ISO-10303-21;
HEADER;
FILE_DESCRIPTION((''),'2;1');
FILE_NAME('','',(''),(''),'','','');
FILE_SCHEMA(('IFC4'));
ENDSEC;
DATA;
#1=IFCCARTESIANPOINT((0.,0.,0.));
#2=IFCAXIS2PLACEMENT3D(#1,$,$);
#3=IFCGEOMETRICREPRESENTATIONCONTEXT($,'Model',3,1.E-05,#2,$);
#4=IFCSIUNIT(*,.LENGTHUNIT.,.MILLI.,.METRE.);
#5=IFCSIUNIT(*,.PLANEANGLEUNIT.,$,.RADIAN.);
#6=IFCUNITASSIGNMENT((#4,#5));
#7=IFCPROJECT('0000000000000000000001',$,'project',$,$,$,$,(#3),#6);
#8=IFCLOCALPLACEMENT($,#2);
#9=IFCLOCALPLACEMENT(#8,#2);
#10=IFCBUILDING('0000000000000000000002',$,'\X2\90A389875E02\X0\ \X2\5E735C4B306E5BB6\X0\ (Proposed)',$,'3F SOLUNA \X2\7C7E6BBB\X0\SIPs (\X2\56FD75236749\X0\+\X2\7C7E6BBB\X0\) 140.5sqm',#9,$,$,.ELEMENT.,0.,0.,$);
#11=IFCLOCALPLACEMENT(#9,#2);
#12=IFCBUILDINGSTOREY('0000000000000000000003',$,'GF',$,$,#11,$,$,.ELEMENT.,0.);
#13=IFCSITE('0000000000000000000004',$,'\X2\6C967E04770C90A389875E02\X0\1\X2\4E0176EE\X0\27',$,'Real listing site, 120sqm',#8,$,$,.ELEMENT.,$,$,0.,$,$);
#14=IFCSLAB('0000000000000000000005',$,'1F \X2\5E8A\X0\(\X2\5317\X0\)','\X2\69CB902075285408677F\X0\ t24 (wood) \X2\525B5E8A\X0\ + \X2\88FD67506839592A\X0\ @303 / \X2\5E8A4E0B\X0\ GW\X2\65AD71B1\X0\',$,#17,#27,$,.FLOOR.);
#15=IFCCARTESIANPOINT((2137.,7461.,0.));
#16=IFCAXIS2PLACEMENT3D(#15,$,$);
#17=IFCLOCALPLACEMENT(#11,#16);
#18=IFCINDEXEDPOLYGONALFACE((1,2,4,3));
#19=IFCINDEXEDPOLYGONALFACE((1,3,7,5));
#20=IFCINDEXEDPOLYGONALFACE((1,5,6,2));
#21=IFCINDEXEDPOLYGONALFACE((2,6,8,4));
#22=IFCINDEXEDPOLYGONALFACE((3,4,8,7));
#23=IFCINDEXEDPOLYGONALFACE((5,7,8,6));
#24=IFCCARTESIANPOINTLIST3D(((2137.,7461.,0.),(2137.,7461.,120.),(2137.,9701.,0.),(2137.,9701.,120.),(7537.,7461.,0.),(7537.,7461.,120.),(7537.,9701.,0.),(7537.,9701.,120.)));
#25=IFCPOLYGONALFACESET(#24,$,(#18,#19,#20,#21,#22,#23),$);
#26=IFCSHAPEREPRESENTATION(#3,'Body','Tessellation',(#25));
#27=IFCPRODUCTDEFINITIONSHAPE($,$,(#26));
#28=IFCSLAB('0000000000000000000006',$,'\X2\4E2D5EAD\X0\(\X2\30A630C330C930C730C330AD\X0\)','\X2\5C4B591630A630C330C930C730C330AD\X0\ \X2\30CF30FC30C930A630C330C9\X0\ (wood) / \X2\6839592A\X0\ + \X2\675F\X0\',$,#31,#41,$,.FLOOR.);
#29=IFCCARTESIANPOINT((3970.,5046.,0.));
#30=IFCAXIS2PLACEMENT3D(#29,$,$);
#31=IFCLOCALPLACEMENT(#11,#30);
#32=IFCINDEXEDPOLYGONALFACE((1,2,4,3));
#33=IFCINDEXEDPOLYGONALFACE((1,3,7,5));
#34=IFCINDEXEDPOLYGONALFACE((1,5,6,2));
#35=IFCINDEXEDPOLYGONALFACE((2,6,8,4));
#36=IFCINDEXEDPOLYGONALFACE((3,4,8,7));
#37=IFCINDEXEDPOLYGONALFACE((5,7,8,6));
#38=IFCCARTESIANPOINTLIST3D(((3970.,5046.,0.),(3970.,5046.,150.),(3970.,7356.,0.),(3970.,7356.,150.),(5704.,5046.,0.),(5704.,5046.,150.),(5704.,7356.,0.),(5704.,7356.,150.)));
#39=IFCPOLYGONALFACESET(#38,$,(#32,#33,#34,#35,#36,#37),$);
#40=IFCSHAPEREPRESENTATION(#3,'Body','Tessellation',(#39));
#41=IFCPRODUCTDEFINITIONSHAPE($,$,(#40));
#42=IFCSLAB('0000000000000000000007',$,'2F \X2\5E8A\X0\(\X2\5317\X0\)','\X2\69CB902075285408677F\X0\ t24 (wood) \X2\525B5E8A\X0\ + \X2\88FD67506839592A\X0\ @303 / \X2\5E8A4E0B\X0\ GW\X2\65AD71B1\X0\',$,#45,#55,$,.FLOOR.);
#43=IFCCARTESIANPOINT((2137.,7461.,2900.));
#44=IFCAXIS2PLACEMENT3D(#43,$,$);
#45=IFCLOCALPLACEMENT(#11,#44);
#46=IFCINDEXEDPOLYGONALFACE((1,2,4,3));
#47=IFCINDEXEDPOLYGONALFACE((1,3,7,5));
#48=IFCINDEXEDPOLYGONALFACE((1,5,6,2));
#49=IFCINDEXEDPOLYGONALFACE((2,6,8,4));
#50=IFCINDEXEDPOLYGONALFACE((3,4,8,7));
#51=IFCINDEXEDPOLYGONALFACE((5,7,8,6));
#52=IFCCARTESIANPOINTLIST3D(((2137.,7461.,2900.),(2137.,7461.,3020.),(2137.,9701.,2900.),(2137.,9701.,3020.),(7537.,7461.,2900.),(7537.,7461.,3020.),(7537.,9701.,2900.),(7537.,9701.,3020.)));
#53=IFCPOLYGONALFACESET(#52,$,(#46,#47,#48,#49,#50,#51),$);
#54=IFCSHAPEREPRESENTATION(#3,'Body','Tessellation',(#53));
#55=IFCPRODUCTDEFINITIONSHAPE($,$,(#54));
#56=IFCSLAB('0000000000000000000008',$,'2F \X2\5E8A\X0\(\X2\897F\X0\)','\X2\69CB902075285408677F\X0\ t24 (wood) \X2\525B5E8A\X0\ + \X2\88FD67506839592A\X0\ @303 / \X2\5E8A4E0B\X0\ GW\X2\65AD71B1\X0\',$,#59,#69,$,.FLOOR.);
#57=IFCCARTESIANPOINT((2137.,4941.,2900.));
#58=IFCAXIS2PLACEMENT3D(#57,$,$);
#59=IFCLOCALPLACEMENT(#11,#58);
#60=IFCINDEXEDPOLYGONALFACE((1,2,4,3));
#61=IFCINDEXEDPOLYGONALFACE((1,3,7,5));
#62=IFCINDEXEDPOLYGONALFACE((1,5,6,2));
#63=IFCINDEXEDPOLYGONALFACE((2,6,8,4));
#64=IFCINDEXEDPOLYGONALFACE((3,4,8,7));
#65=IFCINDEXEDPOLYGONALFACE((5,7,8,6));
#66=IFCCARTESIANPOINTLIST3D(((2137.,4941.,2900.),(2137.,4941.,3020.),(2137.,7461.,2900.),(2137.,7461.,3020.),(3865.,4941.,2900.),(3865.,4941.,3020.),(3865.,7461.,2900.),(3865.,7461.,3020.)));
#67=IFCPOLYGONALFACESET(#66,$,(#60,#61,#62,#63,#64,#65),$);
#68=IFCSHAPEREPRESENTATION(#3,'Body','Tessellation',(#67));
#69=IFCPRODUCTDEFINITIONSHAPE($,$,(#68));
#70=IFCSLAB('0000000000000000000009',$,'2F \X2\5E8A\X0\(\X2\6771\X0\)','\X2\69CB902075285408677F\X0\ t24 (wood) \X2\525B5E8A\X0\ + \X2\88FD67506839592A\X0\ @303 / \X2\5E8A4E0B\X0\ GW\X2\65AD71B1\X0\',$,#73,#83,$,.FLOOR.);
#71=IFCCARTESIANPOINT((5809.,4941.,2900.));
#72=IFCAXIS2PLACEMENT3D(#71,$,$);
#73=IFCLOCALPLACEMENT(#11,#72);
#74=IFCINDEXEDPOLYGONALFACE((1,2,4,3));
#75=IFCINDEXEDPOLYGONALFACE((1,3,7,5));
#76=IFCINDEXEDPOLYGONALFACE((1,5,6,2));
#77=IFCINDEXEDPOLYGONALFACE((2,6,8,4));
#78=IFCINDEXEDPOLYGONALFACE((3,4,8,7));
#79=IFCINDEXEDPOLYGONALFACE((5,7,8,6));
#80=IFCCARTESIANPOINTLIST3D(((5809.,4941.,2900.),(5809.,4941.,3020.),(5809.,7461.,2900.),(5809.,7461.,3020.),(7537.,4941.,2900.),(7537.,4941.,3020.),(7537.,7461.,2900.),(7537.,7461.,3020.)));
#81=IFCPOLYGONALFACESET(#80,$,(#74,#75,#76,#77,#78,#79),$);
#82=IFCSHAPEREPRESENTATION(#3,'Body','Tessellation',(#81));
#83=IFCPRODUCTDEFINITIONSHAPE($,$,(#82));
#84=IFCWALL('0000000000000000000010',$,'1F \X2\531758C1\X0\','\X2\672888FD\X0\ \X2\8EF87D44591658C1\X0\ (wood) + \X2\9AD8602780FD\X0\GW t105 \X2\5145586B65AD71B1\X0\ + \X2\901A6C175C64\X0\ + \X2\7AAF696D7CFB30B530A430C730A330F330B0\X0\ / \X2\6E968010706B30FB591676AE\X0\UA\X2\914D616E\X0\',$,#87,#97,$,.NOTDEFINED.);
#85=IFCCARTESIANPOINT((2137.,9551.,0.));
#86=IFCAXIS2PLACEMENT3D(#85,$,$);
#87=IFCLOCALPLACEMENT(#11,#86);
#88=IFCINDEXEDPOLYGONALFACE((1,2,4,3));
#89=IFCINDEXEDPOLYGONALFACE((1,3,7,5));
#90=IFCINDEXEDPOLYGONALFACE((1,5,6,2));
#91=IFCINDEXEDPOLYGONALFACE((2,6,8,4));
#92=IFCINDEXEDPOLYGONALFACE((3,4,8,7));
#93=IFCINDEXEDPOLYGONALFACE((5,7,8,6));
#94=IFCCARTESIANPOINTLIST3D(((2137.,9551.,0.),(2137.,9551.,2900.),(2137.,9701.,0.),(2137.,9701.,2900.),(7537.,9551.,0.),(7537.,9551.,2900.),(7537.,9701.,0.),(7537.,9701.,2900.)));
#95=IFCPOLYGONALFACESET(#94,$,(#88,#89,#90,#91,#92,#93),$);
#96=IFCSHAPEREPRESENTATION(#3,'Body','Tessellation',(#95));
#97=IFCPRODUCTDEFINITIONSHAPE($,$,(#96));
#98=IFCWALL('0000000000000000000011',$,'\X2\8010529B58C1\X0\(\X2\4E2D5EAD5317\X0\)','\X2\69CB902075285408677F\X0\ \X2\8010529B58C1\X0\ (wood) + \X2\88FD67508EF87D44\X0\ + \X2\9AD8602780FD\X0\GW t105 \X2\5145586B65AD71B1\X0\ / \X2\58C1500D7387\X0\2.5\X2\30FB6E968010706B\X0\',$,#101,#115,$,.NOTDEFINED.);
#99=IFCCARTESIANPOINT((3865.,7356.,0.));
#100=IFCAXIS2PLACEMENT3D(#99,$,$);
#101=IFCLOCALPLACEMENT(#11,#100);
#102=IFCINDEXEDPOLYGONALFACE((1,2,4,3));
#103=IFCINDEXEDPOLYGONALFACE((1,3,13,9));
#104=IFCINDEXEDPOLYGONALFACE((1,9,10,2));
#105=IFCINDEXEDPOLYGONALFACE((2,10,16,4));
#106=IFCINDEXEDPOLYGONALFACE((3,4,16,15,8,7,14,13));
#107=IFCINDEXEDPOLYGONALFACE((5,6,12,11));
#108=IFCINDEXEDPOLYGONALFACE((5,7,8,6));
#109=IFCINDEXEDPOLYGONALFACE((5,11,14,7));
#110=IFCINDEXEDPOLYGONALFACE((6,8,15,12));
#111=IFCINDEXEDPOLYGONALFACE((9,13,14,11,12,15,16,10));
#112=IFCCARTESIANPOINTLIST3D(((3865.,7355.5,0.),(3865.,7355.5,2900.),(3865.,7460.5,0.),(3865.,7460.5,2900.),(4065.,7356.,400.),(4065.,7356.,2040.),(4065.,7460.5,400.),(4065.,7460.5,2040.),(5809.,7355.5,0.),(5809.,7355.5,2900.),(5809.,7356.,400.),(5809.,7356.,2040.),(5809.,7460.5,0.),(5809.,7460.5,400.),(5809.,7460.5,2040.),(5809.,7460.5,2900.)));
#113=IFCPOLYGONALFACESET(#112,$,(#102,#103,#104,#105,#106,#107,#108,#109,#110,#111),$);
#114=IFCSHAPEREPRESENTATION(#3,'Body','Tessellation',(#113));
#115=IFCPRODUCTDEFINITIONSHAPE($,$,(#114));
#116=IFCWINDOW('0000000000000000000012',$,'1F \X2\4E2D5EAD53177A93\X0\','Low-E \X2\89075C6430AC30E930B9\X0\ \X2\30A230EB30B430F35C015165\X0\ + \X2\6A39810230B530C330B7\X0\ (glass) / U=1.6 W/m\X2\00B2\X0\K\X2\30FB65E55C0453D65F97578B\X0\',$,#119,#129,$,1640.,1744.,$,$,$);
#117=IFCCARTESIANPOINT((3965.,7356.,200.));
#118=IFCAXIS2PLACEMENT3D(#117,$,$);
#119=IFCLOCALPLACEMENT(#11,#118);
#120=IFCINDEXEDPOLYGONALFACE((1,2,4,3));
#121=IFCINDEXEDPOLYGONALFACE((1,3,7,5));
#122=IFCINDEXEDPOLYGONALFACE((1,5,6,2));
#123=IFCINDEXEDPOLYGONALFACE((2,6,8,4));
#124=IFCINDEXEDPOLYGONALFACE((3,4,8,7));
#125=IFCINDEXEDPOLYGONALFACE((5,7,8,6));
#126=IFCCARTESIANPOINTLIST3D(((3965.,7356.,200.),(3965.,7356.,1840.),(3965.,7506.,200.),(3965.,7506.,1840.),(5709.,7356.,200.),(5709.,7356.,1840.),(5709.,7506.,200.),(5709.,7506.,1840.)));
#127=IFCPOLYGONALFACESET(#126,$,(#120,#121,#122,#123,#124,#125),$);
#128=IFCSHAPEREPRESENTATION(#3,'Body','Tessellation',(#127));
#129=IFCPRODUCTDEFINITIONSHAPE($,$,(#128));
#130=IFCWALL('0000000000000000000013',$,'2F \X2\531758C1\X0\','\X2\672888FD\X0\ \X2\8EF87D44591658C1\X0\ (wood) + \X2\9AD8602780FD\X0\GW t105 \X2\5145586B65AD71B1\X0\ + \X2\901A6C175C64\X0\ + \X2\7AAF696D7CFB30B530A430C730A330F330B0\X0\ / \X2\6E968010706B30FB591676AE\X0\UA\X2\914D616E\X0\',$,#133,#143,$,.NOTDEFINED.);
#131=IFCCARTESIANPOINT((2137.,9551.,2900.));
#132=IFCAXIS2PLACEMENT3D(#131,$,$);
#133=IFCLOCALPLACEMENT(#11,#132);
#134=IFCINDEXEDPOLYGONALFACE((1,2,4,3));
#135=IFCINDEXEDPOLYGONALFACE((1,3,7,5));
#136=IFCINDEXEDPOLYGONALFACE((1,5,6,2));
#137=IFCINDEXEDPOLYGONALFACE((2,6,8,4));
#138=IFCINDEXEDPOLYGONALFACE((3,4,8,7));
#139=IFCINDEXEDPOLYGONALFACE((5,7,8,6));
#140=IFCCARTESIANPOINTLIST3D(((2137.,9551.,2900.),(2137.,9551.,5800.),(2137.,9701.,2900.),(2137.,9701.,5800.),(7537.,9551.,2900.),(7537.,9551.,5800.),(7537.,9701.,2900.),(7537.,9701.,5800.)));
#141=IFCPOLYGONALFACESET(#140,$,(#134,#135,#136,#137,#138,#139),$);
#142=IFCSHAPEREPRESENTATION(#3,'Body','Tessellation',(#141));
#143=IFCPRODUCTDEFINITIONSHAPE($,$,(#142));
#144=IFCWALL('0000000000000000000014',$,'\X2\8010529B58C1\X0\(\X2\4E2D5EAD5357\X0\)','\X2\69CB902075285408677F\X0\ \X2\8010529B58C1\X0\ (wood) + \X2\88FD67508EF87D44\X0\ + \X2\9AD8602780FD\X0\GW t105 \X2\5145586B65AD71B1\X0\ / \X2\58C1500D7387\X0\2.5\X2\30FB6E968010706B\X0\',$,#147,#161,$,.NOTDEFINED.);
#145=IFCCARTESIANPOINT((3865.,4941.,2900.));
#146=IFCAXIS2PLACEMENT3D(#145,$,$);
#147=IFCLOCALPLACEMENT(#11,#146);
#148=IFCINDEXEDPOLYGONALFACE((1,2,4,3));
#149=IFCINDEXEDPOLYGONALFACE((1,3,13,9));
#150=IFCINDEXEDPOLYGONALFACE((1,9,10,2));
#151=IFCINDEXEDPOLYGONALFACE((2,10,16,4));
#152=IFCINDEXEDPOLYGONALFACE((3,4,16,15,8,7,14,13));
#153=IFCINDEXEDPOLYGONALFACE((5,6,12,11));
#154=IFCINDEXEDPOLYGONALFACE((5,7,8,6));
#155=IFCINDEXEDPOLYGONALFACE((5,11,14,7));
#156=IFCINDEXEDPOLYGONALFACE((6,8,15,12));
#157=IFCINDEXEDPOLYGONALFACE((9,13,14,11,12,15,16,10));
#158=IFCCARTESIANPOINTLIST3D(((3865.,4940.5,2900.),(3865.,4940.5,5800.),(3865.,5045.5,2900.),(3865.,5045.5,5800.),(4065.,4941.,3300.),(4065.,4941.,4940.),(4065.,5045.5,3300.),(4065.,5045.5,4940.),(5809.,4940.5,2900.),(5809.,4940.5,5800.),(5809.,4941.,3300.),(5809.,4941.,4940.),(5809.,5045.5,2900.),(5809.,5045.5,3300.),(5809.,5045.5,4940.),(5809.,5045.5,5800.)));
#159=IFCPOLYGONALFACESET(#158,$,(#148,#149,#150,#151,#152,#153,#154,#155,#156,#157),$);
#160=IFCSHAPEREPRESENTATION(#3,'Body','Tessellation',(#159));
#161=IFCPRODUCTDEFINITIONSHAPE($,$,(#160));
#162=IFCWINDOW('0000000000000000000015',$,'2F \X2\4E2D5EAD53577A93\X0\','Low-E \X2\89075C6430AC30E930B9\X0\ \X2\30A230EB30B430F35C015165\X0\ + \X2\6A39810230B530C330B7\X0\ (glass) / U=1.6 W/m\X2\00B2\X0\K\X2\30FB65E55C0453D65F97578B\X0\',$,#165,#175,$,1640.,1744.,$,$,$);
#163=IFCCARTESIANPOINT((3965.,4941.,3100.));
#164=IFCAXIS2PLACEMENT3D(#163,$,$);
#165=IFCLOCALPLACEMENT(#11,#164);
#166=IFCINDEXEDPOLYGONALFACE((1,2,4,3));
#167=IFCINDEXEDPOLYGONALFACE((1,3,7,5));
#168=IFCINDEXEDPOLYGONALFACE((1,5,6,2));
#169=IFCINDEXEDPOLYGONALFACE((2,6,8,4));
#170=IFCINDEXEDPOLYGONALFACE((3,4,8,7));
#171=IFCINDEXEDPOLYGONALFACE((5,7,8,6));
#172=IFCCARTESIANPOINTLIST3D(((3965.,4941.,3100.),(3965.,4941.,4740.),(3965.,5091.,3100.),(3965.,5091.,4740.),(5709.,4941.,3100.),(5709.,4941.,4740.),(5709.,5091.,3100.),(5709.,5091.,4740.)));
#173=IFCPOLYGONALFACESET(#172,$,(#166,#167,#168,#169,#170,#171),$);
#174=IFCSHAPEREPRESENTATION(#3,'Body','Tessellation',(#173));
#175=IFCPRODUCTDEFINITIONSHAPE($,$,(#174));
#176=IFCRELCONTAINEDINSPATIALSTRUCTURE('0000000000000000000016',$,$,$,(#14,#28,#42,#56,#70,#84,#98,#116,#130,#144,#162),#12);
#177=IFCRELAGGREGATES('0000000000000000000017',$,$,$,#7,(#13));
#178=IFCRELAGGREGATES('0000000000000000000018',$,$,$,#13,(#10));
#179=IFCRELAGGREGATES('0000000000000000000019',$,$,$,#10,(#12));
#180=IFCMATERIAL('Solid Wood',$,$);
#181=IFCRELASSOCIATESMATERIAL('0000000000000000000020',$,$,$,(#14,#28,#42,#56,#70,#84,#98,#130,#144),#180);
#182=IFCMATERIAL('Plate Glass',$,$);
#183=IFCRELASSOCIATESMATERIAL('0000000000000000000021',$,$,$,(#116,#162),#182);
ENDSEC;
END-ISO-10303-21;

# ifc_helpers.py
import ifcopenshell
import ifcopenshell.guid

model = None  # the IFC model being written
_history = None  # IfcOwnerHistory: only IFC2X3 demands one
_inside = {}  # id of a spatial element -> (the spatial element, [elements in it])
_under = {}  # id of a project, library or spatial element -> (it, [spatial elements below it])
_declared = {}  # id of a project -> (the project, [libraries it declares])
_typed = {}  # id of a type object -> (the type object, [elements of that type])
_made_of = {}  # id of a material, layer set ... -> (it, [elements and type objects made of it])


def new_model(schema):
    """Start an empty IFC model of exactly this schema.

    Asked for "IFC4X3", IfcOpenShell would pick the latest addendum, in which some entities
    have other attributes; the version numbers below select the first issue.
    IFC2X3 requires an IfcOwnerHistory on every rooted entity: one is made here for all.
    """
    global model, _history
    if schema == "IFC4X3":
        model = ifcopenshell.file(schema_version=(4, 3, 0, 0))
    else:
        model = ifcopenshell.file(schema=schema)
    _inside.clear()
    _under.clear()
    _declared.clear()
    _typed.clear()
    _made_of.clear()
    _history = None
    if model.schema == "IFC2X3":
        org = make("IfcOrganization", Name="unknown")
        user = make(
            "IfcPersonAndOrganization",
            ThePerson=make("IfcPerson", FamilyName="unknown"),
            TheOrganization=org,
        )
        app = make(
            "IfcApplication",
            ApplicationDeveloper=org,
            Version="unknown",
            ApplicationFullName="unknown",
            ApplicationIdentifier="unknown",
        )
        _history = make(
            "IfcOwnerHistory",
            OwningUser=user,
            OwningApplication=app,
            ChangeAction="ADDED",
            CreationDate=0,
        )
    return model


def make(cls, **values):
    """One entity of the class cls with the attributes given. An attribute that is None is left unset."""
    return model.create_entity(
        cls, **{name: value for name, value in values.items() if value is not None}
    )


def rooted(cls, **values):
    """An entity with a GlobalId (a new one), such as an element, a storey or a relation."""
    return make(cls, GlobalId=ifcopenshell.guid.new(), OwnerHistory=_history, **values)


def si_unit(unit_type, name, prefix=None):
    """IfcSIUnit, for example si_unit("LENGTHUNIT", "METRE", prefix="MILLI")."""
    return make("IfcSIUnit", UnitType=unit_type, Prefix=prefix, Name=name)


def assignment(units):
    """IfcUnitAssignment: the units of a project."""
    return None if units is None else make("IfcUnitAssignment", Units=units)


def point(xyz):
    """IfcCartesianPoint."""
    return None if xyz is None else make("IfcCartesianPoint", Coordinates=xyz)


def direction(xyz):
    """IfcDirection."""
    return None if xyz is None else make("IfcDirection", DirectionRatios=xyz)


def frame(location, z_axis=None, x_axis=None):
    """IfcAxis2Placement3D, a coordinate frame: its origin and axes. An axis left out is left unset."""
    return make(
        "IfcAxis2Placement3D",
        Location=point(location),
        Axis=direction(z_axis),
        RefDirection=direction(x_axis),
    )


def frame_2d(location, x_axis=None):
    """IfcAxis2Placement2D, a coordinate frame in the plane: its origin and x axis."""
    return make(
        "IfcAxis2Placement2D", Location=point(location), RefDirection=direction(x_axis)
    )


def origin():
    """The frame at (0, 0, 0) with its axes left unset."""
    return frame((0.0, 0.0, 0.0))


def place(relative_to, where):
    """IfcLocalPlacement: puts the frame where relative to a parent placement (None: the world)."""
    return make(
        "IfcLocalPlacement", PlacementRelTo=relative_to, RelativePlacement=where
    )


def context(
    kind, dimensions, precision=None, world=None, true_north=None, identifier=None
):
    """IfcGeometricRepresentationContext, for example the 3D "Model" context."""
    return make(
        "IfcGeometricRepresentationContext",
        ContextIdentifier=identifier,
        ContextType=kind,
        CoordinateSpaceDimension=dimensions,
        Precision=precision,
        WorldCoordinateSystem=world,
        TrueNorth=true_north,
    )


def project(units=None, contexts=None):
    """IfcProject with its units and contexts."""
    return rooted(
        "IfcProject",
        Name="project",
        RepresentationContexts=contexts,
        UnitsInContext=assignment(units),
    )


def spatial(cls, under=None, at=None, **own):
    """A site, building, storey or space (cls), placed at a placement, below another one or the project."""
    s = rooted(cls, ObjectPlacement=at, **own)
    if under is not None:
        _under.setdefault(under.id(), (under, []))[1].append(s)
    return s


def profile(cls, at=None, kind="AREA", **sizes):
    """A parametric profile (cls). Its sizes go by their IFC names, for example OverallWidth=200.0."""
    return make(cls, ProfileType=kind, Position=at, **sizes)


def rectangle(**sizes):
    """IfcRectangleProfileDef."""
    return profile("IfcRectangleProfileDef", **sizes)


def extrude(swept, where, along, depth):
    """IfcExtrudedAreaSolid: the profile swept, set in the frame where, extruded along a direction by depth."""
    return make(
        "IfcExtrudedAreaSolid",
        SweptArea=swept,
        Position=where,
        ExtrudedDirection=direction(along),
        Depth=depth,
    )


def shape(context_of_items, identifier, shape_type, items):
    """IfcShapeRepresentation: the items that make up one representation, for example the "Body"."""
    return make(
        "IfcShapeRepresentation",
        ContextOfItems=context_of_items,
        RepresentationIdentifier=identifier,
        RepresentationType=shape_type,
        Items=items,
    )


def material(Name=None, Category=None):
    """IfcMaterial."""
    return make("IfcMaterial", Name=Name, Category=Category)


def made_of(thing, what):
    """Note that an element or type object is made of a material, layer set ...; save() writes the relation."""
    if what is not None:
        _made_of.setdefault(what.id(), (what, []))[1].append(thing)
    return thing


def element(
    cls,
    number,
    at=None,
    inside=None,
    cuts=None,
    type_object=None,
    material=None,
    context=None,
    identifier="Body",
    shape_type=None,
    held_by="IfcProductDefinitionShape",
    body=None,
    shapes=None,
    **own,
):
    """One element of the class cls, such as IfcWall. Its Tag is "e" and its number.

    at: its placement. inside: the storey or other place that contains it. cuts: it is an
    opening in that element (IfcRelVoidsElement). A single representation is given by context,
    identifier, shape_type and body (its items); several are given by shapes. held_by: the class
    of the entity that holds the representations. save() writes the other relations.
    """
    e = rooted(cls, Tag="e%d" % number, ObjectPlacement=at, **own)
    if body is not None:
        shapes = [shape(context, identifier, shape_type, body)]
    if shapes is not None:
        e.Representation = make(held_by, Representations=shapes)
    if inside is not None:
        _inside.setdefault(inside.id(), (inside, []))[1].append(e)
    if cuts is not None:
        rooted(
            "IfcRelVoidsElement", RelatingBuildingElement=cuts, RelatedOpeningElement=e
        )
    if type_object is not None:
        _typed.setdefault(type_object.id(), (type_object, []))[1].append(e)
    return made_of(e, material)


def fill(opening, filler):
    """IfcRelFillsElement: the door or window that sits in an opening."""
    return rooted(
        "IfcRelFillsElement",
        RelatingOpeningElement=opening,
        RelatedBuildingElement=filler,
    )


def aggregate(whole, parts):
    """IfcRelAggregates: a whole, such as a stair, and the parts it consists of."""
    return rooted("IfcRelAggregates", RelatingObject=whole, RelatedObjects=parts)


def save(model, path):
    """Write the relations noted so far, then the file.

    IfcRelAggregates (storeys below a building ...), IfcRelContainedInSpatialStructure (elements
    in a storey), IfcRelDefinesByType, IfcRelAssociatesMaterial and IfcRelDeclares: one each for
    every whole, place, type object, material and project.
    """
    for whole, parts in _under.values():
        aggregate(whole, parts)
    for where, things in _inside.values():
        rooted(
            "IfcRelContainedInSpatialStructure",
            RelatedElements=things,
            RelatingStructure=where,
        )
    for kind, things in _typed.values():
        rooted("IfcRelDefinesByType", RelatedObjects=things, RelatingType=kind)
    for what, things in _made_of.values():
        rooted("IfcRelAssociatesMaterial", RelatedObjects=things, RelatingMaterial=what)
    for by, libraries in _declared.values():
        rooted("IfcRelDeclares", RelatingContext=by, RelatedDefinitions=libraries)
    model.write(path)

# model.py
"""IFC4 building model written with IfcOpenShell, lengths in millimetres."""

from ifc_helpers import new_model, si_unit, frame, frame_2d, origin, place, context, project, spatial, rectangle, extrude, material, element, fill, save


model = new_model("IFC4")

# Units and contexts
model_context = context("Model", 3, precision=1e-05, world=origin())
ifc_project = project(units=[si_unit("LENGTHUNIT", "METRE", prefix="MILLI"), si_unit("PLANEANGLEUNIT", "RADIAN")], contexts=[model_context])

# Site, building, storey
site_placement = place(None, origin())
site = spatial("IfcSite", under=ifc_project, at=site_placement, Name="沖縄県那覇市1丁目27", ObjectType="Real listing site, 120sqm", CompositionType="ELEMENT", RefElevation=0.0)
building_placement = place(site_placement, origin())
building = spatial("IfcBuilding", under=site, at=building_placement, Name="那覇市 平屋の家 (Proposed)", ObjectType="3F SOLUNA 籾殻SIPs (国産杉+籾殻) 140.5sqm", CompositionType="ELEMENT", ElevationOfRefHeight=0.0, ElevationOfTerrain=0.0)
storey_placement = place(building_placement, origin())
storey = spatial("IfcBuildingStorey", under=building, at=storey_placement, Name="GF", CompositionType="ELEMENT", Elevation=0.0)

# Slabs
ifc_material_1 = material(Name="Solid Wood")
slab_1_placement = place(storey_placement, frame((2137.0, 7461.0, 0.0)))
element("IfcSlab", 1, at=slab_1_placement, inside=storey, material=ifc_material_1, Name="1F 床(北)", Description="構造用合板 t24 (wood) 剛床 + 製材根太 @303 / 床下 GW断熱", PredefinedType="FLOOR", context=model_context, shape_type="SweptSolid", body=[
    extrude(rectangle(XDim=5400.0, YDim=2240.0, at=frame_2d((2700.0, 1120.0))), frame((2137.0, 7461.0, 0.0)), (0.0, 0.0, 1.0), 120.0),
])
slab_2_placement = place(storey_placement, frame((3970.0, 5046.0, 0.0)))
element("IfcSlab", 2, at=slab_2_placement, inside=storey, material=ifc_material_1, Name="中庭(ウッドデッキ)", Description="屋外ウッドデッキ ハードウッド (wood) / 根太 + 束", PredefinedType="FLOOR", context=model_context, shape_type="SweptSolid", body=[
    extrude(rectangle(XDim=1734.0, YDim=2310.0, at=frame_2d((867.0, 1155.0))), frame((3970.0, 5046.0, 0.0)), (0.0, 0.0, 1.0), 150.0),
])
slab_3_placement = place(storey_placement, frame((2137.0, 7461.0, 2900.0)))
element("IfcSlab", 3, at=slab_3_placement, inside=storey, material=ifc_material_1, Name="2F 床(北)", Description="構造用合板 t24 (wood) 剛床 + 製材根太 @303 / 床下 GW断熱", PredefinedType="FLOOR", context=model_context, shape_type="SweptSolid", body=[
    extrude(rectangle(XDim=5400.0, YDim=2240.0, at=frame_2d((2700.0, 1120.0))), frame((2137.0, 7461.0, 2900.0)), (0.0, 0.0, 1.0), 120.0),
])
slab_4_placement = place(storey_placement, frame((2137.0, 4941.0, 2900.0)))
element("IfcSlab", 4, at=slab_4_placement, inside=storey, material=ifc_material_1, Name="2F 床(西)", Description="構造用合板 t24 (wood) 剛床 + 製材根太 @303 / 床下 GW断熱", PredefinedType="FLOOR", context=model_context, shape_type="SweptSolid", body=[
    extrude(rectangle(XDim=1728.0, YDim=2520.0, at=frame_2d((864.0, 1260.0))), frame((2137.0, 4941.0, 2900.0)), (0.0, 0.0, 1.0), 120.0),
])
slab_5_placement = place(storey_placement, frame((5809.0, 4941.0, 2900.0)))
element("IfcSlab", 5, at=slab_5_placement, inside=storey, material=ifc_material_1, Name="2F 床(東)", Description="構造用合板 t24 (wood) 剛床 + 製材根太 @303 / 床下 GW断熱", PredefinedType="FLOOR", context=model_context, shape_type="SweptSolid", body=[
    extrude(rectangle(XDim=1728.0, YDim=2520.0, at=frame_2d((864.0, 1260.0))), frame((5809.0, 4941.0, 2900.0)), (0.0, 0.0, 1.0), 120.0),
])

# Wall
wall_1_placement = place(storey_placement, frame((2137.0, 9551.0, 0.0)))
element("IfcWall", 6, at=wall_1_placement, inside=storey, material=ifc_material_1, Name="1F 北壁", Description="木製 軸組外壁 (wood) + 高性能GW t105 充填断熱 + 通気層 + 窯業系サイディング / 準耐火・外皮UA配慮", PredefinedType="NOTDEFINED", context=model_context, shape_type="SweptSolid", body=[
    extrude(rectangle(XDim=5400.0, YDim=150.0, at=frame_2d((2700.0, 75.0))), frame((2137.0, 9551.0, 0.0)), (0.0, 0.0, 1.0), 2900.0),
])

# Wall, opening, window
wall_2_placement = place(storey_placement, frame((3865.0, 7356.0, 0.0)))
wall_2 = element("IfcWall", 7, at=wall_2_placement, inside=storey, material=ifc_material_1, Name="耐力壁(中庭北)", Description="構造用合板 耐力壁 (wood) + 製材軸組 + 高性能GW t105 充填断熱 / 壁倍率2.5・準耐火", PredefinedType="NOTDEFINED", context=model_context, shape_type="SweptSolid", body=[
    extrude(rectangle(XDim=1944.0, YDim=105.0, at=frame_2d((972.0, 52.0))), frame((3865.0, 7356.0, 0.0)), (0.0, 0.0, 1.0), 2900.0),
])
opening_1_placement = place(storey_placement, frame((3965.0, 7356.0, 200.0)))
opening_1 = element("IfcOpeningElement", 8, at=opening_1_placement, cuts=wall_2, PredefinedType="NOTDEFINED", context=model_context, shape_type="SweptSolid", body=[
    extrude(rectangle(XDim=1744.0, YDim=150.0, at=frame_2d((872.0, 75.0))), frame((3965.0, 7356.0, 200.0)), (0.0, 0.0, 1.0), 1640.0),
])
ifc_material_2 = material(Name="Plate Glass")
window_1_placement = place(storey_placement, frame((3965.0, 7356.0, 200.0)))
window_1 = element("IfcWindow", 9, at=window_1_placement, inside=storey, material=ifc_material_2, Name="1F 中庭北窓", Description="Low-E 複層ガラス アルゴン封入 + 樹脂サッシ (glass) / U=1.6 W/m²K・日射取得型", OverallHeight=1640.0, OverallWidth=1744.0, context=model_context, shape_type="SweptSolid", body=[
    extrude(rectangle(XDim=1744.0, YDim=150.0, at=frame_2d((872.0, 75.0))), frame((3965.0, 7356.0, 200.0)), (0.0, 0.0, 1.0), 1640.0),
])
fill(opening_1, window_1)

# Wall
wall_3_placement = place(storey_placement, frame((2137.0, 9551.0, 2900.0)))
element("IfcWall", 10, at=wall_3_placement, inside=storey, material=ifc_material_1, Name="2F 北壁", Description="木製 軸組外壁 (wood) + 高性能GW t105 充填断熱 + 通気層 + 窯業系サイディング / 準耐火・外皮UA配慮", PredefinedType="NOTDEFINED", context=model_context, shape_type="SweptSolid", body=[
    extrude(rectangle(XDim=5400.0, YDim=150.0, at=frame_2d((2700.0, 75.0))), frame((2137.0, 9551.0, 2900.0)), (0.0, 0.0, 1.0), 2900.0),
])

# Wall, opening, window
wall_4_placement = place(storey_placement, frame((3865.0, 4941.0, 2900.0)))
wall_4 = element("IfcWall", 11, at=wall_4_placement, inside=storey, material=ifc_material_1, Name="耐力壁(中庭南)", Description="構造用合板 耐力壁 (wood) + 製材軸組 + 高性能GW t105 充填断熱 / 壁倍率2.5・準耐火", PredefinedType="NOTDEFINED", context=model_context, shape_type="SweptSolid", body=[
    extrude(rectangle(XDim=1944.0, YDim=105.0, at=frame_2d((972.0, 52.0))), frame((3865.0, 4941.0, 2900.0)), (0.0, 0.0, 1.0), 2900.0),
])
opening_2_placement = place(storey_placement, frame((3965.0, 4941.0, 3100.0)))
opening_2 = element("IfcOpeningElement", 12, at=opening_2_placement, cuts=wall_4, PredefinedType="NOTDEFINED", context=model_context, shape_type="SweptSolid", body=[
    extrude(rectangle(XDim=1744.0, YDim=150.0, at=frame_2d((872.0, 75.0))), frame((3965.0, 4941.0, 3100.0)), (0.0, 0.0, 1.0), 1640.0),
])
window_2_placement = place(storey_placement, frame((3965.0, 4941.0, 3100.0)))
window_2 = element("IfcWindow", 13, at=window_2_placement, inside=storey, material=ifc_material_2, Name="2F 中庭南窓", Description="Low-E 複層ガラス アルゴン封入 + 樹脂サッシ (glass) / U=1.6 W/m²K・日射取得型", OverallHeight=1640.0, OverallWidth=1744.0, context=model_context, shape_type="SweptSolid", body=[
    extrude(rectangle(XDim=1744.0, YDim=150.0, at=frame_2d((872.0, 75.0))), frame((3965.0, 4941.0, 3100.0)), (0.0, 0.0, 1.0), 1640.0),
])
fill(opening_2, window_2)

save(model, "model.ifc")
